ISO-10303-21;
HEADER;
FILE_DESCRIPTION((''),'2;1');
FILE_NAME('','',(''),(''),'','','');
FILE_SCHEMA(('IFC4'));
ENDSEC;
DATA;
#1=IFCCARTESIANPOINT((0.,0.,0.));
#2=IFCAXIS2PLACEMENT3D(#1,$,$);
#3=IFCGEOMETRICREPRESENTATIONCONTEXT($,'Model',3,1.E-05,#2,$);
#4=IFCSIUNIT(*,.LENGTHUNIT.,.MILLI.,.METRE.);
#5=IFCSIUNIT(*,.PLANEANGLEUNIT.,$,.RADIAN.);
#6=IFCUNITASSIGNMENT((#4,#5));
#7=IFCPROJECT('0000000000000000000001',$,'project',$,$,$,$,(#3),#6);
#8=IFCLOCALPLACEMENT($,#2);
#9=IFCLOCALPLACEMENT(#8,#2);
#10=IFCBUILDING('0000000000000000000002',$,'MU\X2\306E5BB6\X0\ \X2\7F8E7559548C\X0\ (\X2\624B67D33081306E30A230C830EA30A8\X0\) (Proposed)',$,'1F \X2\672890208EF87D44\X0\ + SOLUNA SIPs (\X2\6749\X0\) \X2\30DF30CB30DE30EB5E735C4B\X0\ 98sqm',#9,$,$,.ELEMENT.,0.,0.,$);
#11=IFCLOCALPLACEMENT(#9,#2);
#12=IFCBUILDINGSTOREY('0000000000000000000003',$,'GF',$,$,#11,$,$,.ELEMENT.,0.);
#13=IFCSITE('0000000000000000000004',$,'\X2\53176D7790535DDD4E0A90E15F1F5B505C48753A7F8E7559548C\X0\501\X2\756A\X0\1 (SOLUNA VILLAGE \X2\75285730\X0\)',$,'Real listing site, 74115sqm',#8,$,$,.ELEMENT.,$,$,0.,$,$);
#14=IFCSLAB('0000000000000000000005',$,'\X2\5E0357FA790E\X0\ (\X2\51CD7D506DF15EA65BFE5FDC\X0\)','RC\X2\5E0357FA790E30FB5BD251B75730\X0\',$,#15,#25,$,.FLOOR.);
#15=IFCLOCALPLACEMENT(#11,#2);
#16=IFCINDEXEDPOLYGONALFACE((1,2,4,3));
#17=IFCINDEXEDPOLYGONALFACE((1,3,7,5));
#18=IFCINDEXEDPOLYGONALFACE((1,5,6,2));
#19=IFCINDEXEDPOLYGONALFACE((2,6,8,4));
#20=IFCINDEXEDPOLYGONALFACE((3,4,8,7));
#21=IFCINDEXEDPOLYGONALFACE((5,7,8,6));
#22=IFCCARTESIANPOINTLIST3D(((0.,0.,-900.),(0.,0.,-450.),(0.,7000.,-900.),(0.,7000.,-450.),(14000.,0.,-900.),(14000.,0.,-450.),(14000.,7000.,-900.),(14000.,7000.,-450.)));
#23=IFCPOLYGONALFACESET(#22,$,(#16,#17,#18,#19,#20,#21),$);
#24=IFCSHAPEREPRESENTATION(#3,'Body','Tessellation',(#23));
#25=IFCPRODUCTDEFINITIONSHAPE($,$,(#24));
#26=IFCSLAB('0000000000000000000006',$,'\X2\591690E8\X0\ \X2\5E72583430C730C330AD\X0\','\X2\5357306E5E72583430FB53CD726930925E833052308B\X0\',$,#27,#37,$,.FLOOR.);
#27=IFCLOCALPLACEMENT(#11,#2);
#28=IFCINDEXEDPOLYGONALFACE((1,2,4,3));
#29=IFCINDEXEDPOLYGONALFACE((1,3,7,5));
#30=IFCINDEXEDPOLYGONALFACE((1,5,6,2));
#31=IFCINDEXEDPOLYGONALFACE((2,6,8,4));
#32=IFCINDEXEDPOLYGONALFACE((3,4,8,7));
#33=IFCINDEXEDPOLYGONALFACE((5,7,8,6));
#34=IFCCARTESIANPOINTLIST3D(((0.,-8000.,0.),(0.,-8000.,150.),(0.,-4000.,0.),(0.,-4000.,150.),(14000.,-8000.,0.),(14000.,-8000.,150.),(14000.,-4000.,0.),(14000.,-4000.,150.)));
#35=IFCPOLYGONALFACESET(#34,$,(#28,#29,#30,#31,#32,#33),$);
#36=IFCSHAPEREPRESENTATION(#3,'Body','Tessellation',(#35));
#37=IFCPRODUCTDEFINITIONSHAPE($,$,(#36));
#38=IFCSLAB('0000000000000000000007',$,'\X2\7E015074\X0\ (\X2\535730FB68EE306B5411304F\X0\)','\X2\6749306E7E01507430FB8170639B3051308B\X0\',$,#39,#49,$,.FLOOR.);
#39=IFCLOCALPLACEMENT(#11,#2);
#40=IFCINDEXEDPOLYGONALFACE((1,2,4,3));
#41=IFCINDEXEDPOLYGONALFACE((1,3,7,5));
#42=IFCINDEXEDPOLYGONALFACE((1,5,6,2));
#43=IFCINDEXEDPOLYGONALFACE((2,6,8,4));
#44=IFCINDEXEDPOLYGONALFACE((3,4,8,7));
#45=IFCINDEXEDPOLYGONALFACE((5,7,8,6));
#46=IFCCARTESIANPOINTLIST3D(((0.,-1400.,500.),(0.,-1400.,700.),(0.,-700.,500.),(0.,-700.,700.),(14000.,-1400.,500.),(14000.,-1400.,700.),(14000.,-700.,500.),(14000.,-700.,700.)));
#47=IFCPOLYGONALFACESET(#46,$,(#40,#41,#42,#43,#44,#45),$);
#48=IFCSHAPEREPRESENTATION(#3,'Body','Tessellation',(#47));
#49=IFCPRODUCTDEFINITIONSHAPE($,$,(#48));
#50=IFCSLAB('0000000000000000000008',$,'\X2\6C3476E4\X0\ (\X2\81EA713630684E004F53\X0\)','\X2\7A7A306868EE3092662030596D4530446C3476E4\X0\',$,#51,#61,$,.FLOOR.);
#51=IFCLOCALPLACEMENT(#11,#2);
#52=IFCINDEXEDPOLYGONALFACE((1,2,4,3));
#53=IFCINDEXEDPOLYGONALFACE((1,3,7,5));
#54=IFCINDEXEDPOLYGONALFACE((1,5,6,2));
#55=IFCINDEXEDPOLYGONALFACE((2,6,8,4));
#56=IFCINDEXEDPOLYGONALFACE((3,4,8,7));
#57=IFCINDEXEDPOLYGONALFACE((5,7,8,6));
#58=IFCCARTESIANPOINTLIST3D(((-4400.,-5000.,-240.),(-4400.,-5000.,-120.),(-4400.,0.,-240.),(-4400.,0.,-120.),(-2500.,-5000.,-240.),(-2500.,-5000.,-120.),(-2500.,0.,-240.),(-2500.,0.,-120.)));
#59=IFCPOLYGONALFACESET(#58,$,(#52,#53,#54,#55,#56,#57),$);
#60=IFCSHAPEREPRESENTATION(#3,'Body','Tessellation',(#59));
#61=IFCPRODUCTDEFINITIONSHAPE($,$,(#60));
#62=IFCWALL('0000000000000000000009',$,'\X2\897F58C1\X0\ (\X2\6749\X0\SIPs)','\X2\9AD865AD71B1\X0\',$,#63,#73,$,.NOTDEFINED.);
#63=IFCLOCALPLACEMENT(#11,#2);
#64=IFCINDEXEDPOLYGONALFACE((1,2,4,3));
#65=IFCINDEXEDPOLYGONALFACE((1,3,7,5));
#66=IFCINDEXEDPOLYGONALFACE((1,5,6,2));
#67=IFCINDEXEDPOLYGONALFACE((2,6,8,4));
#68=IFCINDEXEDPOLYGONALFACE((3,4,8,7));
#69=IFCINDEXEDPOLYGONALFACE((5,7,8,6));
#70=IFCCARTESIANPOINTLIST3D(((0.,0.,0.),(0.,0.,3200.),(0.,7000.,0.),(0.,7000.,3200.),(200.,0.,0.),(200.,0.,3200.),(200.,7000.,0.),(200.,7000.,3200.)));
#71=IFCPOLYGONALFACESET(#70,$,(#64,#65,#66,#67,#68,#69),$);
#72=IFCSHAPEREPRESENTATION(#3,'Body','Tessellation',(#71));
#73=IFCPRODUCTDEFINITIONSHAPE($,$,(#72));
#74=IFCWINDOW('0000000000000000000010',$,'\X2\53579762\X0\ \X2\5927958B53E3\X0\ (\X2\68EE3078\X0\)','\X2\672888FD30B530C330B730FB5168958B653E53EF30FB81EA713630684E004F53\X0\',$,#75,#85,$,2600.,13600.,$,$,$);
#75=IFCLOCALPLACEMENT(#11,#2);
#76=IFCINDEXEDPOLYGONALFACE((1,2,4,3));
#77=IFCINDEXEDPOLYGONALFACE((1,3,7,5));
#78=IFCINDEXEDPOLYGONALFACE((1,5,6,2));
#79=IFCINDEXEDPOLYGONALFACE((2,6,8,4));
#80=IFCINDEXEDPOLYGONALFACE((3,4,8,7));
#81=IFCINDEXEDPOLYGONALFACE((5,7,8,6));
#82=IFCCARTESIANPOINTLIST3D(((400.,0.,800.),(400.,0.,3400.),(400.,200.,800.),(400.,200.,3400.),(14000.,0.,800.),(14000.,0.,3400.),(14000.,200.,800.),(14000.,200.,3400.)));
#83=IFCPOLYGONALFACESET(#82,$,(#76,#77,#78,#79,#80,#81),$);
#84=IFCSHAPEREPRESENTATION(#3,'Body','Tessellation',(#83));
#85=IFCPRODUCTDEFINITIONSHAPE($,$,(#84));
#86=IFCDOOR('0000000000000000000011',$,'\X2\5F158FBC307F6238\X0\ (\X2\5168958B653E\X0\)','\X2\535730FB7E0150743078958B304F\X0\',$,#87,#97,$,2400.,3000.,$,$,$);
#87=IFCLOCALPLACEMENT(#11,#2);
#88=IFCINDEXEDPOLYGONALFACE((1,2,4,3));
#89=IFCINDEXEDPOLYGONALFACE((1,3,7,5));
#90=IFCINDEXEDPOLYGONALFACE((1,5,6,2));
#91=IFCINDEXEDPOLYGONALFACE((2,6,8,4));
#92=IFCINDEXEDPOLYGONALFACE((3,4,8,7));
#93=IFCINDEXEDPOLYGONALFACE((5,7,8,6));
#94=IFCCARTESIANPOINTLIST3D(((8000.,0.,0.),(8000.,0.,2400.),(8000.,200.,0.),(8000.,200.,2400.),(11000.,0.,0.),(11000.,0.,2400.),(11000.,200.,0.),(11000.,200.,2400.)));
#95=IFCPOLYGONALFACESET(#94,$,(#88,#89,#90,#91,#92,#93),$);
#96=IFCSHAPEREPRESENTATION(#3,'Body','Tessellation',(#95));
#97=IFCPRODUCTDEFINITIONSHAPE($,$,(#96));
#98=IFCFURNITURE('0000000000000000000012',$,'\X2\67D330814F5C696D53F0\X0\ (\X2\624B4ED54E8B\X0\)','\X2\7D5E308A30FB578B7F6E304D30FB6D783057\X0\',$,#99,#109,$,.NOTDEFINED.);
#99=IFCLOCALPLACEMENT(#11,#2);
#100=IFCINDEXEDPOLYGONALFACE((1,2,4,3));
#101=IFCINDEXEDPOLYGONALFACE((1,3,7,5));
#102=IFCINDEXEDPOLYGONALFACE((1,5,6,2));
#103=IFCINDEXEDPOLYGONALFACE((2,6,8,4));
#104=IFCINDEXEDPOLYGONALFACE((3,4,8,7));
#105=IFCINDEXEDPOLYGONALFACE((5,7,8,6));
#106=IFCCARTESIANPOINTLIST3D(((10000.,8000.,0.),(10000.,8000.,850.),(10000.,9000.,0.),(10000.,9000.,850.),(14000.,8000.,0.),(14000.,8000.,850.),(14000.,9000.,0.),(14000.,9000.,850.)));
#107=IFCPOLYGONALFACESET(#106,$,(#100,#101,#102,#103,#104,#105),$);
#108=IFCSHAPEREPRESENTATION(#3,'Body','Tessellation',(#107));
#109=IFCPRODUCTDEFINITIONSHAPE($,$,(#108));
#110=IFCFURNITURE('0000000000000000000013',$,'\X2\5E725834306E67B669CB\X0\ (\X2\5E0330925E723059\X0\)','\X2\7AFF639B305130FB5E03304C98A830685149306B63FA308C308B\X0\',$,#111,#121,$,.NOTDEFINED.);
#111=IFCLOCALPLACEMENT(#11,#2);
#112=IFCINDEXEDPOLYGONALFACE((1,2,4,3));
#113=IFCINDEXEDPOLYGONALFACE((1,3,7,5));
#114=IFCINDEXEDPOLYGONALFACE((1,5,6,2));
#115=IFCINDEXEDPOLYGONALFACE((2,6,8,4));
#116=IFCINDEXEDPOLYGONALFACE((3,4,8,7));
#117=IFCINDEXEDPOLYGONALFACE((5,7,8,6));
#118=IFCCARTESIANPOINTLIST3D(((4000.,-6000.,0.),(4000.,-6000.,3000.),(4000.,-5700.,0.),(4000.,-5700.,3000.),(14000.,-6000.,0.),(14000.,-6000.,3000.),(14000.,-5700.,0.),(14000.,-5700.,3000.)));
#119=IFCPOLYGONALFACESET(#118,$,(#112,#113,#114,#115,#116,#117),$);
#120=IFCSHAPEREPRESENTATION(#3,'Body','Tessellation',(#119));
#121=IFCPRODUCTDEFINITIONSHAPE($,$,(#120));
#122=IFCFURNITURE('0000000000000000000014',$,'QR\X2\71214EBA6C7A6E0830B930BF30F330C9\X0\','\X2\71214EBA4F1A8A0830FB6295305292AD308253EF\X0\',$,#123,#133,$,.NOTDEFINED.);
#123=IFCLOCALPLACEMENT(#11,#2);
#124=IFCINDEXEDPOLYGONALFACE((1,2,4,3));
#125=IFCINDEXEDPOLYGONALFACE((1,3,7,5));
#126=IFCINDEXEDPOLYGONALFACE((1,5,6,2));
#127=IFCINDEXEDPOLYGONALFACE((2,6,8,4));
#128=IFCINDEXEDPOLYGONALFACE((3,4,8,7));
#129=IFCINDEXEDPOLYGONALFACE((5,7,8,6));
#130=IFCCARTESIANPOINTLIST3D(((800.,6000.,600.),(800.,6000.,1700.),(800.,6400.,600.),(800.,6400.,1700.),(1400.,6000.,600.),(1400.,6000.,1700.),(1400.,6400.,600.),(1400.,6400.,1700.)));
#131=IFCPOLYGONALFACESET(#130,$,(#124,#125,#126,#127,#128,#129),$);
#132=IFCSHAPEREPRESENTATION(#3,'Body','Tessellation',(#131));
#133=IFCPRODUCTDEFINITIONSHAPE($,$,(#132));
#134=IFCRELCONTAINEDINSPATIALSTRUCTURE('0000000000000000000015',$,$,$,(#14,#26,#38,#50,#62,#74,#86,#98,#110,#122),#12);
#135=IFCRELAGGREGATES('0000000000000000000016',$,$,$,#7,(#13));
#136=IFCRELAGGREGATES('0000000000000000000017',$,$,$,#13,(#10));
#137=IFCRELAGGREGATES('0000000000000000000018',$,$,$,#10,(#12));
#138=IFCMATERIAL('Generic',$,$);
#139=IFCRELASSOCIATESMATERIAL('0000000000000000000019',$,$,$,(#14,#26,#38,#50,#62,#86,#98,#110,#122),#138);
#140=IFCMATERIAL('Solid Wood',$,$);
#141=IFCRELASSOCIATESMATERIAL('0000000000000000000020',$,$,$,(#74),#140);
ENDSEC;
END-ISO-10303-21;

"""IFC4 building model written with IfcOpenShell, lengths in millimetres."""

from ifc_helpers import new_model, si_unit, frame, frame_2d, origin, place, context, project, spatial, rectangle, extrude, material, element, save


model = new_model("IFC4")

# Units and contexts
model_context = context("Model", 3, precision=1e-05, world=origin())
ifc_project = project(units=[si_unit("LENGTHUNIT", "METRE", prefix="MILLI"), si_unit("PLANEANGLEUNIT", "RADIAN")], contexts=[model_context])

# Site, building, storey
site_placement = place(None, origin())
site = spatial("IfcSite", under=ifc_project, at=site_placement, Name="北海道川上郡弟子屈町美留和501番1 (SOLUNA VILLAGE 用地)", ObjectType="Real listing site, 74115sqm", CompositionType="ELEMENT", RefElevation=0.0)
building_placement = place(site_placement, origin())
building = spatial("IfcBuilding", under=site, at=building_placement, Name="MUの家 美留和 (手染めのアトリエ) (Proposed)", ObjectType="1F 木造軸組 + SOLUNA SIPs (杉) ミニマル平屋 98sqm", CompositionType="ELEMENT", ElevationOfRefHeight=0.0, ElevationOfTerrain=0.0)
storey_placement = place(building_placement, origin())
storey = spatial("IfcBuildingStorey", under=building, at=storey_placement, Name="GF", CompositionType="ELEMENT", Elevation=0.0)

# Slabs
ifc_material_1 = material(Name="Generic")
slab_1_placement = place(storey_placement, frame((0.0, 0.0, -450.0)))
element("IfcSlab", 1, at=slab_1_placement, inside=storey, material=ifc_material_1, Name="布基礎 (凍結深度対応)", Description="RC布基礎・寒冷地", PredefinedType="FLOOR", context=model_context, shape_type="SweptSolid", body=[
    extrude(rectangle(XDim=14000.0, YDim=7000.0, at=frame_2d((7000.0, 3500.0))), frame((0.0, 0.0, -450.0)), (0.0, 0.0, 1.0), 450.0),
])
slab_2_placement = place(storey_placement, frame((0.0, -4000.0, 0.0)))
element("IfcSlab", 2, at=slab_2_placement, inside=storey, material=ifc_material_1, Name="外部 干場デッキ", Description="南の干場・反物を広げる", PredefinedType="FLOOR", context=model_context, shape_type="SweptSolid", body=[
    extrude(rectangle(XDim=14000.0, YDim=4000.0, at=frame_2d((7000.0, 2000.0))), frame((0.0, -4000.0, 0.0)), (0.0, 0.0, 1.0), 150.0),
])
slab_3_placement = place(storey_placement, frame((0.0, -700.0, 250.0)))
element("IfcSlab", 3, at=slab_3_placement, inside=storey, material=ifc_material_1, Name="縁側 (南・森に向く)", Description="杉の縁側・腰掛ける", PredefinedType="FLOOR", context=model_context, shape_type="SweptSolid", body=[
    extrude(rectangle(XDim=14000.0, YDim=700.0, at=frame_2d((7000.0, 350.0))), frame((0.0, -700.0, 250.0)), (0.0, 0.0, 1.0), 200.0),
])
slab_4_placement = place(storey_placement, frame((-2200.0, -2500.0, -120.0)))
element("IfcSlab", 4, at=slab_4_placement, inside=storey, material=ifc_material_1, Name="水盤 (自然と一体)", Description="空と森を映す浅い水盤", PredefinedType="FLOOR", context=model_context, shape_type="SweptSolid", body=[
    extrude(rectangle(XDim=1900.0, YDim=5000.0, at=frame_2d((950.0, 2500.0))), frame((-2200.0, -2500.0, -120.0)), (0.0, 0.0, 1.0), 120.0),
])

# Wall
wall_1_placement = place(storey_placement, origin())
element("IfcWall", 5, at=wall_1_placement, inside=storey, material=ifc_material_1, Name="西壁 (杉SIPs)", Description="高断熱", PredefinedType="NOTDEFINED", context=model_context, shape_type="SweptSolid", body=[
    extrude(rectangle(XDim=200.0, YDim=7000.0, at=frame_2d((100.0, 3500.0))), origin(), (0.0, 0.0, 1.0), 3200.0),
])

# Window
ifc_material_2 = material(Name="Solid Wood")
window_placement = place(storey_placement, frame((200.0, 0.0, 400.0)))
element("IfcWindow", 6, at=window_placement, inside=storey, material=ifc_material_2, Name="南面 大開口 (森へ)", Description="木製サッシ・全開放可・自然と一体", OverallHeight=2600.0, OverallWidth=13600.0, context=model_context, shape_type="SweptSolid", body=[
    extrude(rectangle(XDim=13600.0, YDim=200.0, at=frame_2d((6800.0, 100.0))), frame((200.0, 0.0, 400.0)), (0.0, 0.0, 1.0), 2600.0),
])

# Door
door_placement = place(storey_placement, frame((4000.0, 0.0, 0.0)))
element("IfcDoor", 7, at=door_placement, inside=storey, material=ifc_material_1, Name="引込み戸 (全開放)", Description="南・縁側へ開く", OverallHeight=2400.0, OverallWidth=3000.0, context=model_context, shape_type="SweptSolid", body=[
    extrude(rectangle(XDim=3000.0, YDim=200.0, at=frame_2d((1500.0, 100.0))), frame((4000.0, 0.0, 0.0)), (0.0, 0.0, 1.0), 2400.0),
])

# Furniture
furniture_1_placement = place(storey_placement, frame((5000.0, 4000.0, 0.0)))
element("IfcFurniture", 8, at=furniture_1_placement, inside=storey, material=ifc_material_1, Name="染め作業台 (手仕事)", Description="絞り・型置き・浸し", PredefinedType="NOTDEFINED", context=model_context, shape_type="SweptSolid", body=[
    extrude(rectangle(XDim=4000.0, YDim=1000.0, at=frame_2d((2000.0, 500.0))), frame((5000.0, 4000.0, 0.0)), (0.0, 0.0, 1.0), 850.0),
])
furniture_2_placement = place(storey_placement, frame((2000.0, -3000.0, 0.0)))
element("IfcFurniture", 9, at=furniture_2_placement, inside=storey, material=ifc_material_1, Name="干場の架構 (布を干す)", Description="竿掛け・布が風と光に揺れる", PredefinedType="NOTDEFINED", context=model_context, shape_type="SweptSolid", body=[
    extrude(rectangle(XDim=10000.0, YDim=300.0, at=frame_2d((5000.0, 150.0))), frame((2000.0, -3000.0, 0.0)), (0.0, 0.0, 1.0), 3000.0),
])
furniture_3_placement = place(storey_placement, frame((400.0, 3000.0, 300.0)))
element("IfcFurniture", 10, at=furniture_3_placement, inside=storey, material=ifc_material_1, Name="QR無人決済スタンド", Description="無人会計・投げ銭も可", PredefinedType="NOTDEFINED", context=model_context, shape_type="SweptSolid", body=[
    extrude(rectangle(XDim=600.0, YDim=400.0, at=frame_2d((300.0, 200.0))), frame((400.0, 3000.0, 300.0)), (0.0, 0.0, 1.0), 1100.0),
])

save(model, "model.ifc")
